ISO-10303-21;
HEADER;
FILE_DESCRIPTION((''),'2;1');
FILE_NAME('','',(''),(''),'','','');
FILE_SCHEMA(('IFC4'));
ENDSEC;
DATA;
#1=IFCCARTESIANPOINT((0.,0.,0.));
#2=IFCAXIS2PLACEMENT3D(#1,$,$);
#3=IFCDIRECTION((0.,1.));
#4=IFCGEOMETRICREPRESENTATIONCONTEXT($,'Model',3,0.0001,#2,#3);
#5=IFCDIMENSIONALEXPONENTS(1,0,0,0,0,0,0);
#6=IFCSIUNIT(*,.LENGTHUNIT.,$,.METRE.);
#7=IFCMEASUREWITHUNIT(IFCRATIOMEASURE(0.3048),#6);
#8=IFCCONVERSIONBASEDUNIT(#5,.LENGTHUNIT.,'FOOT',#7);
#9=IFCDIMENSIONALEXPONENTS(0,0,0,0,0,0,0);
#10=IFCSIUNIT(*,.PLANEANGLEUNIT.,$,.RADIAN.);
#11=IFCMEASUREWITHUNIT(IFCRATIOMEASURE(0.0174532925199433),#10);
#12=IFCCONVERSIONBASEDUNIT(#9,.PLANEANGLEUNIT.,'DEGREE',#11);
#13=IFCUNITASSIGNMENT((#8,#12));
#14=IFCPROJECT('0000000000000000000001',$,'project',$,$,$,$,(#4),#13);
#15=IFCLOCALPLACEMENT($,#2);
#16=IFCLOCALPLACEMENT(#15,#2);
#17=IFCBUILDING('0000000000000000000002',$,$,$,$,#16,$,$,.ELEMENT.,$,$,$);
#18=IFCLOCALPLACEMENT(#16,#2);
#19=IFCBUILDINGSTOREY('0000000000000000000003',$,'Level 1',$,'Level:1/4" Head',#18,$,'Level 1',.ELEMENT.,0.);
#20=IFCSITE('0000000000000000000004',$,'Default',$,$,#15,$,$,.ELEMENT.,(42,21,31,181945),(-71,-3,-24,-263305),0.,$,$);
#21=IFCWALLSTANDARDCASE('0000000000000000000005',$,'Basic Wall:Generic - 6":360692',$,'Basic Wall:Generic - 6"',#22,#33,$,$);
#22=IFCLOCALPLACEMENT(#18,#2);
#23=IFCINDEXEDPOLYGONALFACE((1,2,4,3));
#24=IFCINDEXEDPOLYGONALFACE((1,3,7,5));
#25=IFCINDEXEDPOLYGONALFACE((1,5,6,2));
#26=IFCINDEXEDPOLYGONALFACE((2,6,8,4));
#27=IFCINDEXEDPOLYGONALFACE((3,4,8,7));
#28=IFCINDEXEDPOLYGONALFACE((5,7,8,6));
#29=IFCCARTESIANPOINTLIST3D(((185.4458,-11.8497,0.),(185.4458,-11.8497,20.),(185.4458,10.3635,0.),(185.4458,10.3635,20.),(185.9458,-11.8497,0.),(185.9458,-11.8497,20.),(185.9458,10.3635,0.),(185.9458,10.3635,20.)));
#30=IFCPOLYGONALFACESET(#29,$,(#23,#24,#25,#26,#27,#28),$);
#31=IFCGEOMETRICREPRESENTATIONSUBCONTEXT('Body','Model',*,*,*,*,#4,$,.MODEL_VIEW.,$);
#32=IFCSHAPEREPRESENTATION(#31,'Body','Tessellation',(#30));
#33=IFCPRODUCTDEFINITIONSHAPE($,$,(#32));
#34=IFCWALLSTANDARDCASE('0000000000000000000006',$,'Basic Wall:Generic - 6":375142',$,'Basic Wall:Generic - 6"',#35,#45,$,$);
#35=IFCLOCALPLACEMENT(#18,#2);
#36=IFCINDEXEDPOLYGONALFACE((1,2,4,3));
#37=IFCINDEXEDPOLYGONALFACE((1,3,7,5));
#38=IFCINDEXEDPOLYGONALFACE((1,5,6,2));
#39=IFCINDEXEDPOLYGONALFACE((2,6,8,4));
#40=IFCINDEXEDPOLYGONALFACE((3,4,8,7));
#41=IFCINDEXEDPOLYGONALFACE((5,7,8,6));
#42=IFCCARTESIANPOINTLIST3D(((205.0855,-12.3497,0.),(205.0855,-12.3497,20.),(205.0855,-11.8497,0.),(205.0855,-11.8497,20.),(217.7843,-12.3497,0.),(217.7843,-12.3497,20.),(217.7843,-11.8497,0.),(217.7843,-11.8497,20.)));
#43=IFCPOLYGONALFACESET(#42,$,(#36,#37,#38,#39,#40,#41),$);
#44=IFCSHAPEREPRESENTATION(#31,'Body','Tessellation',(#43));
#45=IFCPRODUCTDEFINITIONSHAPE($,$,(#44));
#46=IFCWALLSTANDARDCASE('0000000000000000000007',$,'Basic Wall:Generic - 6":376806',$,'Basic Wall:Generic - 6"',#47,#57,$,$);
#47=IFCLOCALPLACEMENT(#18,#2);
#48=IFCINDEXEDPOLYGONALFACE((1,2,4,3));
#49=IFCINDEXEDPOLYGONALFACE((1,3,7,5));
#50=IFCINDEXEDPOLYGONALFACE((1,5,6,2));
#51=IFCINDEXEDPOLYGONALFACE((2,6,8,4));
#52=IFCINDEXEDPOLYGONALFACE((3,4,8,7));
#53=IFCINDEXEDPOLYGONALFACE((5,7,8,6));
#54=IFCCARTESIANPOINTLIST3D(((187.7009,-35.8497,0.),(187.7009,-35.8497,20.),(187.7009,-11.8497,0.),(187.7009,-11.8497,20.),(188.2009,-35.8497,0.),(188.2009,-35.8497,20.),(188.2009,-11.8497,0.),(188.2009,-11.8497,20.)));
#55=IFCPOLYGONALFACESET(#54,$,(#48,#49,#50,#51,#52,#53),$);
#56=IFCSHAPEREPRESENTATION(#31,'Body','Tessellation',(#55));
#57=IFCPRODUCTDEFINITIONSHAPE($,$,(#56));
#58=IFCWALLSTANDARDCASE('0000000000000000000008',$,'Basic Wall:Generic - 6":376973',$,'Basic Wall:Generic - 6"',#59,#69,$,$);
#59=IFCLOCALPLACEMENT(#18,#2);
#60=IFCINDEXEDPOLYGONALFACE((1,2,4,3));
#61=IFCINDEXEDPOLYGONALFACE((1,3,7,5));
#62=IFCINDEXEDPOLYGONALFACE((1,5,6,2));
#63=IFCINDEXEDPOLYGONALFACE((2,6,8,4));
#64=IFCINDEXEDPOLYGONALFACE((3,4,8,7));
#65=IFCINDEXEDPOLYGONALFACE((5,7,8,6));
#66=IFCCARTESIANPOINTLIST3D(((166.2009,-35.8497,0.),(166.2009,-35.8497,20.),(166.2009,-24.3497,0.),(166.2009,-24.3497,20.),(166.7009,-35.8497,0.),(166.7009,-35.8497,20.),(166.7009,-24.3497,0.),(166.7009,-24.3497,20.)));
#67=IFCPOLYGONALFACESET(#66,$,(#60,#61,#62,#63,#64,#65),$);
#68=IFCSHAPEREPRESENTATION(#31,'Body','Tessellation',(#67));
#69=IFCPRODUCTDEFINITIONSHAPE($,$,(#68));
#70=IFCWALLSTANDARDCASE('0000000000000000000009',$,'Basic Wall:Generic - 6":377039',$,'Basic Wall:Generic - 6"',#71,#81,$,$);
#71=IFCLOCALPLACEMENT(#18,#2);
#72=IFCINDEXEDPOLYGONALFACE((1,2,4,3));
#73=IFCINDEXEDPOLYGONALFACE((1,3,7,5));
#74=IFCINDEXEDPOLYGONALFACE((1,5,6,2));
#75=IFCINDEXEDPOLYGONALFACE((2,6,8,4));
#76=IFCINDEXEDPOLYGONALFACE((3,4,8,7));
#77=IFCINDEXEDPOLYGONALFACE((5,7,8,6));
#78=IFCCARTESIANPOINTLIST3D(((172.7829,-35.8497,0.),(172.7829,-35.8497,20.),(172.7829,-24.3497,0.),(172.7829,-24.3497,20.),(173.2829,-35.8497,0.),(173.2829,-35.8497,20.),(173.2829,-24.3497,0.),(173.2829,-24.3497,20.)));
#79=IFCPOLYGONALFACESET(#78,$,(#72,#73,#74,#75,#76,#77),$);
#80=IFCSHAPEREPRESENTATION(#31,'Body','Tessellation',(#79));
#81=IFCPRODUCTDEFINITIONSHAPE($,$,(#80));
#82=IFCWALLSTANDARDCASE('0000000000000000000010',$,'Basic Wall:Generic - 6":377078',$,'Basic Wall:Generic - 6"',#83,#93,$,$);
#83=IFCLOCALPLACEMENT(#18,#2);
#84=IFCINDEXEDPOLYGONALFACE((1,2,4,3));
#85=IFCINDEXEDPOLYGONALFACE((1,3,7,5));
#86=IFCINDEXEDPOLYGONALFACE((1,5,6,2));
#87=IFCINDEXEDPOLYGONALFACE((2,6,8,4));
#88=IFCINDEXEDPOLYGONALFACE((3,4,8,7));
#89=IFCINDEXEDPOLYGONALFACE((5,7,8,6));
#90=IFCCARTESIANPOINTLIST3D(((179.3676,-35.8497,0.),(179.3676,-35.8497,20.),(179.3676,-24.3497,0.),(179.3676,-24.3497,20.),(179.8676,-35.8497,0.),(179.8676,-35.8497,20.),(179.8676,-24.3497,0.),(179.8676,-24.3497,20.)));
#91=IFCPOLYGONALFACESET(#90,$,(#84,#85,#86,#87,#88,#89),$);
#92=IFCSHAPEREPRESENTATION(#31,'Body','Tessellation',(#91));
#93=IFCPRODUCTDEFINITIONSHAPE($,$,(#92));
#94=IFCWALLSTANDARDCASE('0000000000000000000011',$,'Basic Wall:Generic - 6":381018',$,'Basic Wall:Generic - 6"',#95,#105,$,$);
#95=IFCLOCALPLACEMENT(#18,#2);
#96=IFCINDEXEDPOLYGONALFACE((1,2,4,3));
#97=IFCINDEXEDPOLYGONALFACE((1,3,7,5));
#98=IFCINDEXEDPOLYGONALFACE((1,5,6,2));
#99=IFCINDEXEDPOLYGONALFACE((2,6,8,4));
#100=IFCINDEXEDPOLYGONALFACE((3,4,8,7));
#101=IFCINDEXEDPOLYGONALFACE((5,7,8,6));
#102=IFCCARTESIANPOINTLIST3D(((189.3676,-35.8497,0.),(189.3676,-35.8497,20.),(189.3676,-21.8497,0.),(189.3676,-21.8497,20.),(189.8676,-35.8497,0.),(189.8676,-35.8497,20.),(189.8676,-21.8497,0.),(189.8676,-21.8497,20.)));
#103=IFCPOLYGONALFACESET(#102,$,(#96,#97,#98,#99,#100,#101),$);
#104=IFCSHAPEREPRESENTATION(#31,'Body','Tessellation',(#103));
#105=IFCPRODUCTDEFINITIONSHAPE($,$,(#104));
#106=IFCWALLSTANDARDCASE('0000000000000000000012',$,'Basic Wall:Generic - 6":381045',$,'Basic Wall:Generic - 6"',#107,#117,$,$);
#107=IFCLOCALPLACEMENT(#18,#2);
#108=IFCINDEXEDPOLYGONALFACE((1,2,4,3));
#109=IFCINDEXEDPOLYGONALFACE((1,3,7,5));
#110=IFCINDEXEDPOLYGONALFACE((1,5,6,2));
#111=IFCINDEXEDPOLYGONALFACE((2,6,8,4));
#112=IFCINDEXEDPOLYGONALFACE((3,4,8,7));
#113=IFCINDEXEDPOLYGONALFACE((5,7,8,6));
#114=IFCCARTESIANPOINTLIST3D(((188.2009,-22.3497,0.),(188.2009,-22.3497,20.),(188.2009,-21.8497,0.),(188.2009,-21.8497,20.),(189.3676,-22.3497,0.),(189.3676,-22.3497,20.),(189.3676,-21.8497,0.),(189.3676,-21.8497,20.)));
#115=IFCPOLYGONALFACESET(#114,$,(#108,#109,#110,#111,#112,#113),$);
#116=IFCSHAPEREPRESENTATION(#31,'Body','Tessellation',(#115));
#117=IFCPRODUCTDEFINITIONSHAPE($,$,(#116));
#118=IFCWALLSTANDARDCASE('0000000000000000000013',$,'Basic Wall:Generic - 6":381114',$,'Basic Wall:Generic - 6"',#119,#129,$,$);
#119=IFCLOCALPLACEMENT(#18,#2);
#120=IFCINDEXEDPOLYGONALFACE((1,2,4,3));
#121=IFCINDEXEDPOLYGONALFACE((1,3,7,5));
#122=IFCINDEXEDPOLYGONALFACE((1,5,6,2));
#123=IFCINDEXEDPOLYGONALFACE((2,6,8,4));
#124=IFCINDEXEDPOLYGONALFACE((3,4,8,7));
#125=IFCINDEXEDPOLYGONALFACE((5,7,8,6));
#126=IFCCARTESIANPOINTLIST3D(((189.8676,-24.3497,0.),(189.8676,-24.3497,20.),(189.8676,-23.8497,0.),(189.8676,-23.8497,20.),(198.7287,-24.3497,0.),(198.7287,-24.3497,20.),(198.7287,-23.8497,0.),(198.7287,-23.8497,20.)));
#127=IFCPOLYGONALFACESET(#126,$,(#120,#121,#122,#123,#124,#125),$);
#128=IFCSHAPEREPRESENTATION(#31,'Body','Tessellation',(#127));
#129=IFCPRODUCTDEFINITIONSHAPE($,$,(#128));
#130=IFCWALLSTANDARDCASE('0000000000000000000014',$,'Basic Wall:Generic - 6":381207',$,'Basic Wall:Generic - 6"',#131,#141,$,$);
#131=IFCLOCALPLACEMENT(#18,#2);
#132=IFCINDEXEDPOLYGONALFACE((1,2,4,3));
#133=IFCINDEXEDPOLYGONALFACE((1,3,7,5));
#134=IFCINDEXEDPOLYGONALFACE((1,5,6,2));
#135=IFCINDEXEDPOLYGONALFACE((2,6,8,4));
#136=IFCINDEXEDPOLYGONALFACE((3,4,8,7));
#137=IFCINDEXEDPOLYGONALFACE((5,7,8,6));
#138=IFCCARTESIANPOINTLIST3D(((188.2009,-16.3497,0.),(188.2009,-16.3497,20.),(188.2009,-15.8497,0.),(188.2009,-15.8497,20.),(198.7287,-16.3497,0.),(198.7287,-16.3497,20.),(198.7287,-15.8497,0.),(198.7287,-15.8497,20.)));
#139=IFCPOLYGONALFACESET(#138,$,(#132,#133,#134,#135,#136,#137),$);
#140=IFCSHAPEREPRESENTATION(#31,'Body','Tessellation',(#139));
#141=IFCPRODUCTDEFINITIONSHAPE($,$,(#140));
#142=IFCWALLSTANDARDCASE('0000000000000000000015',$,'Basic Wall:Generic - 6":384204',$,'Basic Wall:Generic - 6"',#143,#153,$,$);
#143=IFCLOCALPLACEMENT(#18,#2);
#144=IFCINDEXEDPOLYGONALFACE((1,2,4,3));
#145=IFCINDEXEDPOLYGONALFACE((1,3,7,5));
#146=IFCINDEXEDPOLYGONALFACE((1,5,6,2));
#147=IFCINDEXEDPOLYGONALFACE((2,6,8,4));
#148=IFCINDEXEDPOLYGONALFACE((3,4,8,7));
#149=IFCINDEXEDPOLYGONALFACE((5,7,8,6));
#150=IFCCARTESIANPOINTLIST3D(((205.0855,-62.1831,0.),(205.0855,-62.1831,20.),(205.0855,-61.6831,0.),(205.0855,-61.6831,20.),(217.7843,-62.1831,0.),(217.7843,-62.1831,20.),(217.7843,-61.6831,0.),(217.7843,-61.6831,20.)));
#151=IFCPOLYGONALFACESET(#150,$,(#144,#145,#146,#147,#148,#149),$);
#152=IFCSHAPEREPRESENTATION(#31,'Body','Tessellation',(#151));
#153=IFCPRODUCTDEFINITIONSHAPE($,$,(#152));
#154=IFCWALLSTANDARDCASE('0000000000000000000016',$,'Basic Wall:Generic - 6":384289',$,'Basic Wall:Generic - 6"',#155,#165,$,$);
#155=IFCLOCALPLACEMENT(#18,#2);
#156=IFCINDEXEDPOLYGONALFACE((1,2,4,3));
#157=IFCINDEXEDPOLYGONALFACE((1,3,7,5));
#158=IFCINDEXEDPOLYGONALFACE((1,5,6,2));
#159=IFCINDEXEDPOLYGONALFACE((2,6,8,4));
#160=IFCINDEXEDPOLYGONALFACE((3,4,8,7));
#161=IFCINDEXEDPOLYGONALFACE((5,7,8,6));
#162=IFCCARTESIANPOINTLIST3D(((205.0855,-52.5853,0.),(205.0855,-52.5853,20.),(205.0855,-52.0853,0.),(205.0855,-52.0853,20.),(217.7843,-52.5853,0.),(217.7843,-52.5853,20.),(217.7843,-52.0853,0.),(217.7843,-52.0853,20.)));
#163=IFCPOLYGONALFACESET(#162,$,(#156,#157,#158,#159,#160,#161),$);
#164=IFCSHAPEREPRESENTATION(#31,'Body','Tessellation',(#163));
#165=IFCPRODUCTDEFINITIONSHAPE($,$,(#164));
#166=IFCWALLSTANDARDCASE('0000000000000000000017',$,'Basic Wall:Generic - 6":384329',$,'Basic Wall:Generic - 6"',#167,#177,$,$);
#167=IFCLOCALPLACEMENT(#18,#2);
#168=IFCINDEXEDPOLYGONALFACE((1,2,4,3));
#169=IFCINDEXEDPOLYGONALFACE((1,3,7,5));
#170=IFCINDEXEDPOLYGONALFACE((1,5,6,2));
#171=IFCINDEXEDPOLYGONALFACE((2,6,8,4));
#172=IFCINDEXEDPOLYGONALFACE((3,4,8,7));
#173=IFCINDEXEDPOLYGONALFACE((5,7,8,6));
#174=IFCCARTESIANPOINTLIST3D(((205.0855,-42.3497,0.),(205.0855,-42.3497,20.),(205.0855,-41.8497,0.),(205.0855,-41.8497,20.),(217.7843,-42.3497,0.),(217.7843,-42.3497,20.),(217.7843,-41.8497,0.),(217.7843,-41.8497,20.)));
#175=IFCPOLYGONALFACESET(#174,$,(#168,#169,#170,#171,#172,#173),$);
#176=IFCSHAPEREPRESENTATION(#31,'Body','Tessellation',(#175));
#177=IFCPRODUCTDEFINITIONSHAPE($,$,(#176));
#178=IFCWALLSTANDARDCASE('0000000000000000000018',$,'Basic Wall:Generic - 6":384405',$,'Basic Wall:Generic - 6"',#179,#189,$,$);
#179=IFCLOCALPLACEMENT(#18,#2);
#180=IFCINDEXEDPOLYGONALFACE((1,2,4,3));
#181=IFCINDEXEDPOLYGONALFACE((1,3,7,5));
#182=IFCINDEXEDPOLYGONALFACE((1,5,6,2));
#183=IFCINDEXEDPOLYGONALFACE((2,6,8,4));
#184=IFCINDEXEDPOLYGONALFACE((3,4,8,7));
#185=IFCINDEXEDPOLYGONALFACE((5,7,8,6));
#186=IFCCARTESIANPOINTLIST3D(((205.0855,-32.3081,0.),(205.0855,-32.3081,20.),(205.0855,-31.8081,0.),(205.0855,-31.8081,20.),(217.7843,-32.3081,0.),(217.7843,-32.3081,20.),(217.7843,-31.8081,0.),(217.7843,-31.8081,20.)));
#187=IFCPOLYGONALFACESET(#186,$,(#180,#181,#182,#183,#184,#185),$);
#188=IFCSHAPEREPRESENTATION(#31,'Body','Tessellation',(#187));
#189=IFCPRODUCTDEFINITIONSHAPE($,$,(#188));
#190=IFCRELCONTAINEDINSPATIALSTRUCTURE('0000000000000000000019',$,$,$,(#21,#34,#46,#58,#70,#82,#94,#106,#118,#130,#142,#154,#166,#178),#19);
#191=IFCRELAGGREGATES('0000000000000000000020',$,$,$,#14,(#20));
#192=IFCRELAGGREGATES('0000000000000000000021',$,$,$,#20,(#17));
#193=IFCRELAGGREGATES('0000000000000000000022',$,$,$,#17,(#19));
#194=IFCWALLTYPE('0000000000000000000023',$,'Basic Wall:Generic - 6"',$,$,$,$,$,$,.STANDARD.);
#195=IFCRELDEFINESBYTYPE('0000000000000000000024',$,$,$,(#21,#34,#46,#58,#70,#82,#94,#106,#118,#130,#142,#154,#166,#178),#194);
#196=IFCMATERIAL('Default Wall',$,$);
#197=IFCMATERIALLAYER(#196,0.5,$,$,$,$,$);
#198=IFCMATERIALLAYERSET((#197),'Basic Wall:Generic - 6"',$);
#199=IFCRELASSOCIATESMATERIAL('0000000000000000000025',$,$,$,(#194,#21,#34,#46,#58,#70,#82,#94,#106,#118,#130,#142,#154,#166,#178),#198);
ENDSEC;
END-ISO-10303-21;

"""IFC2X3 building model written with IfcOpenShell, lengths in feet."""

from ifc_helpers import new_model, entity, si_unit, converted_unit, direction, frame, frame_2d, origin, place, context, subcontext, project, spatial, rectangle, extrude, material, layer, layer_set, layer_usage, type_object, element, save


model = new_model("IFC2X3")

# Units and contexts
model_context = context("Model", 3, precision=0.0001, world=origin(), true_north=direction((0.0, 1.0)))
body_context = subcontext(model_context, "Body", "Model", "MODEL_VIEW")
ifc_project = project(units=[converted_unit("LENGTHUNIT", "FOOT", entity("IfcRatioMeasure", 0.3048), si_unit("LENGTHUNIT", "METRE"), dimensions=[1, 0, 0, 0, 0, 0, 0]), converted_unit("PLANEANGLEUNIT", "DEGREE", entity("IfcRatioMeasure", 0.0174532925199433), si_unit("PLANEANGLEUNIT", "RADIAN"), dimensions=[0, 0, 0, 0, 0, 0, 0])], contexts=[model_context])

# Site, building, storey
site_placement = place(None, origin())
site = spatial("IfcSite", under=ifc_project, at=site_placement, Name="Default", CompositionType="ELEMENT", RefLatitude=(42, 21, 31, 181945), RefLongitude=(-71, -3, -24, -263305), RefElevation=0.0)
building_placement = place(site_placement, origin())
building = spatial("IfcBuilding", under=site, at=building_placement, CompositionType="ELEMENT")
storey_placement = place(building_placement, origin())
storey = spatial("IfcBuildingStorey", under=building, at=storey_placement, Name="Level 1", ObjectType="Level:1/4\" Head", LongName="Level 1", CompositionType="ELEMENT", Elevation=0.0)

# Walls
ifc_material = material(Name="Default Wall")
ifc_layer = layer(ifc_material, 0.5)
ifc_layer_set = layer_set([ifc_layer], Name="Basic Wall:Generic - 6\"")
ifc_layer_usage_1 = layer_usage(ifc_layer_set, "AXIS2", "NEGATIVE", 0.25)
wall_type = type_object("IfcWallType", Name="Basic Wall:Generic - 6\"", PredefinedType="STANDARD", material=ifc_layer_set)
wall_1_placement = place(storey_placement, frame((185.6958, -11.8497, 0.0), z_axis=(0.0, 0.0, 1.0), x_axis=(0.0, 1.0, 0.0)))
element("IfcWallStandardCase", 1, at=wall_1_placement, inside=storey, type_object=wall_type, material=ifc_layer_usage_1, Name="Basic Wall:Generic - 6\":360692", ObjectType="Basic Wall:Generic - 6\"", context=body_context, shape_type="SweptSolid", body=[
    extrude(rectangle(XDim=22.2133, YDim=0.5, at=frame_2d((11.1066, 0.0), x_axis=(-1.0, 0.0))), origin(), (0.0, 0.0, 1.0), 20.0),
])
ifc_layer_usage_2 = layer_usage(ifc_layer_set, "AXIS2", "NEGATIVE", 0.25)
wall_2_placement = place(storey_placement, frame((205.0855, -12.0997, 0.0)))
element("IfcWallStandardCase", 2, at=wall_2_placement, inside=storey, type_object=wall_type, material=ifc_layer_usage_2, Name="Basic Wall:Generic - 6\":375142", ObjectType="Basic Wall:Generic - 6\"", context=body_context, shape_type="SweptSolid", body=[
    extrude(rectangle(XDim=12.6987, YDim=0.5, at=frame_2d((6.3494, 0.0), x_axis=(-1.0, 0.0))), origin(), (0.0, 0.0, 1.0), 20.0),
])
ifc_layer_usage_3 = layer_usage(ifc_layer_set, "AXIS2", "NEGATIVE", 0.25)
wall_3_placement = place(storey_placement, frame((187.9509, -35.8497, 0.0), z_axis=(0.0, 0.0, 1.0), x_axis=(0.0, 1.0, 0.0)))
element("IfcWallStandardCase", 3, at=wall_3_placement, inside=storey, type_object=wall_type, material=ifc_layer_usage_3, Name="Basic Wall:Generic - 6\":376806", ObjectType="Basic Wall:Generic - 6\"", context=body_context, shape_type="SweptSolid", body=[
    extrude(rectangle(XDim=24.0, YDim=0.5, at=frame_2d((12.0, 0.0), x_axis=(-1.0, 0.0))), origin(), (0.0, 0.0, 1.0), 20.0),
])
ifc_layer_usage_4 = layer_usage(ifc_layer_set, "AXIS2", "NEGATIVE", 0.25)
wall_4_placement = place(storey_placement, frame((166.4509, -24.3497, 0.0), z_axis=(0.0, 0.0, 1.0), x_axis=(0.0, -1.0, 0.0)))
element("IfcWallStandardCase", 4, at=wall_4_placement, inside=storey, type_object=wall_type, material=ifc_layer_usage_4, Name="Basic Wall:Generic - 6\":376973", ObjectType="Basic Wall:Generic - 6\"", context=body_context, shape_type="SweptSolid", body=[
    extrude(rectangle(XDim=11.5, YDim=0.5, at=frame_2d((5.75, 0.0), x_axis=(-1.0, 0.0))), origin(), (0.0, 0.0, 1.0), 20.0),
])
ifc_layer_usage_5 = layer_usage(ifc_layer_set, "AXIS2", "NEGATIVE", 0.25)
wall_5_placement = place(storey_placement, frame((173.0329, -24.3497, 0.0), z_axis=(0.0, 0.0, 1.0), x_axis=(0.0, -1.0, 0.0)))
element("IfcWallStandardCase", 5, at=wall_5_placement, inside=storey, type_object=wall_type, material=ifc_layer_usage_5, Name="Basic Wall:Generic - 6\":377039", ObjectType="Basic Wall:Generic - 6\"", context=body_context, shape_type="SweptSolid", body=[
    extrude(rectangle(XDim=11.5, YDim=0.5, at=frame_2d((5.75, 0.0), x_axis=(-1.0, 0.0))), origin(), (0.0, 0.0, 1.0), 20.0),
])
ifc_layer_usage_6 = layer_usage(ifc_layer_set, "AXIS2", "NEGATIVE", 0.25)
wall_6_placement = place(storey_placement, frame((179.6176, -24.3497, 0.0), z_axis=(0.0, 0.0, 1.0), x_axis=(0.0, -1.0, 0.0)))
element("IfcWallStandardCase", 6, at=wall_6_placement, inside=storey, type_object=wall_type, material=ifc_layer_usage_6, Name="Basic Wall:Generic - 6\":377078", ObjectType="Basic Wall:Generic - 6\"", context=body_context, shape_type="SweptSolid", body=[
    extrude(rectangle(XDim=11.5, YDim=0.5, at=frame_2d((5.75, 0.0), x_axis=(-1.0, 0.0))), origin(), (0.0, 0.0, 1.0), 20.0),
])
ifc_layer_usage_7 = layer_usage(ifc_layer_set, "AXIS2", "NEGATIVE", 0.25)
wall_7_placement = place(storey_placement, frame((189.6176, -35.8497, 0.0), z_axis=(0.0, 0.0, 1.0), x_axis=(0.0, 1.0, 0.0)))
element("IfcWallStandardCase", 7, at=wall_7_placement, inside=storey, type_object=wall_type, material=ifc_layer_usage_7, Name="Basic Wall:Generic - 6\":381018", ObjectType="Basic Wall:Generic - 6\"", context=body_context, shape_type="SweptSolid", body=[
    extrude(rectangle(XDim=14.0, YDim=0.5, at=frame_2d((7.0, 0.0), x_axis=(-1.0, 0.0))), origin(), (0.0, 0.0, 1.0), 20.0),
])
ifc_layer_usage_8 = layer_usage(ifc_layer_set, "AXIS2", "NEGATIVE", 0.25)
wall_8_placement = place(storey_placement, frame((189.3676, -22.0997, 0.0), z_axis=(0.0, 0.0, 1.0), x_axis=(-1.0, 0.0, 0.0)))
element("IfcWallStandardCase", 8, at=wall_8_placement, inside=storey, type_object=wall_type, material=ifc_layer_usage_8, Name="Basic Wall:Generic - 6\":381045", ObjectType="Basic Wall:Generic - 6\"", context=body_context, shape_type="SweptSolid", body=[
    extrude(rectangle(XDim=1.1667, YDim=0.5, at=frame_2d((0.5833, 0.0), x_axis=(-1.0, 0.0))), origin(), (0.0, 0.0, 1.0), 20.0),
])
ifc_layer_usage_9 = layer_usage(ifc_layer_set, "AXIS2", "NEGATIVE", 0.25)
wall_9_placement = place(storey_placement, frame((189.8676, -24.0997, 0.0)))
element("IfcWallStandardCase", 9, at=wall_9_placement, inside=storey, type_object=wall_type, material=ifc_layer_usage_9, Name="Basic Wall:Generic - 6\":381114", ObjectType="Basic Wall:Generic - 6\"", context=body_context, shape_type="SweptSolid", body=[
    extrude(rectangle(XDim=8.8611, YDim=0.5, at=frame_2d((4.4305, 0.0), x_axis=(-1.0, 0.0))), origin(), (0.0, 0.0, 1.0), 20.0),
])
ifc_layer_usage_10 = layer_usage(ifc_layer_set, "AXIS2", "NEGATIVE", 0.25)
wall_10_placement = place(storey_placement, frame((188.2009, -16.0997, 0.0)))
element("IfcWallStandardCase", 10, at=wall_10_placement, inside=storey, type_object=wall_type, material=ifc_layer_usage_10, Name="Basic Wall:Generic - 6\":381207", ObjectType="Basic Wall:Generic - 6\"", context=body_context, shape_type="SweptSolid", body=[
    extrude(rectangle(XDim=10.5278, YDim=0.5, at=frame_2d((5.2639, 0.0), x_axis=(-1.0, 0.0))), origin(), (0.0, 0.0, 1.0), 20.0),
])
ifc_layer_usage_11 = layer_usage(ifc_layer_set, "AXIS2", "NEGATIVE", 0.25)
wall_11_placement = place(storey_placement, frame((205.0855, -61.9331, 0.0)))
element("IfcWallStandardCase", 11, at=wall_11_placement, inside=storey, type_object=wall_type, material=ifc_layer_usage_11, Name="Basic Wall:Generic - 6\":384204", ObjectType="Basic Wall:Generic - 6\"", context=body_context, shape_type="SweptSolid", body=[
    extrude(rectangle(XDim=12.6987, YDim=0.5, at=frame_2d((6.3494, 0.0), x_axis=(-1.0, 0.0))), origin(), (0.0, 0.0, 1.0), 20.0),
])
ifc_layer_usage_12 = layer_usage(ifc_layer_set, "AXIS2", "NEGATIVE", 0.25)
wall_12_placement = place(storey_placement, frame((205.0855, -52.3353, 0.0)))
element("IfcWallStandardCase", 12, at=wall_12_placement, inside=storey, type_object=wall_type, material=ifc_layer_usage_12, Name="Basic Wall:Generic - 6\":384289", ObjectType="Basic Wall:Generic - 6\"", context=body_context, shape_type="SweptSolid", body=[
    extrude(rectangle(XDim=12.6987, YDim=0.5, at=frame_2d((6.3494, 0.0), x_axis=(-1.0, 0.0))), origin(), (0.0, 0.0, 1.0), 20.0),
])
ifc_layer_usage_13 = layer_usage(ifc_layer_set, "AXIS2", "NEGATIVE", 0.25)
wall_13_placement = place(storey_placement, frame((205.0855, -42.0997, 0.0)))
element("IfcWallStandardCase", 13, at=wall_13_placement, inside=storey, type_object=wall_type, material=ifc_layer_usage_13, Name="Basic Wall:Generic - 6\":384329", ObjectType="Basic Wall:Generic - 6\"", context=body_context, shape_type="SweptSolid", body=[
    extrude(rectangle(XDim=12.6987, YDim=0.5, at=frame_2d((6.3494, 0.0), x_axis=(-1.0, 0.0))), origin(), (0.0, 0.0, 1.0), 20.0),
])
ifc_layer_usage_14 = layer_usage(ifc_layer_set, "AXIS2", "NEGATIVE", 0.25)
wall_14_placement = place(storey_placement, frame((205.0855, -32.0581, 0.0)))
element("IfcWallStandardCase", 14, at=wall_14_placement, inside=storey, type_object=wall_type, material=ifc_layer_usage_14, Name="Basic Wall:Generic - 6\":384405", ObjectType="Basic Wall:Generic - 6\"", context=body_context, shape_type="SweptSolid", body=[
    extrude(rectangle(XDim=12.6987, YDim=0.5, at=frame_2d((6.3494, 0.0), x_axis=(-1.0, 0.0))), origin(), (0.0, 0.0, 1.0), 20.0),
])

save(model, "model.ifc")
